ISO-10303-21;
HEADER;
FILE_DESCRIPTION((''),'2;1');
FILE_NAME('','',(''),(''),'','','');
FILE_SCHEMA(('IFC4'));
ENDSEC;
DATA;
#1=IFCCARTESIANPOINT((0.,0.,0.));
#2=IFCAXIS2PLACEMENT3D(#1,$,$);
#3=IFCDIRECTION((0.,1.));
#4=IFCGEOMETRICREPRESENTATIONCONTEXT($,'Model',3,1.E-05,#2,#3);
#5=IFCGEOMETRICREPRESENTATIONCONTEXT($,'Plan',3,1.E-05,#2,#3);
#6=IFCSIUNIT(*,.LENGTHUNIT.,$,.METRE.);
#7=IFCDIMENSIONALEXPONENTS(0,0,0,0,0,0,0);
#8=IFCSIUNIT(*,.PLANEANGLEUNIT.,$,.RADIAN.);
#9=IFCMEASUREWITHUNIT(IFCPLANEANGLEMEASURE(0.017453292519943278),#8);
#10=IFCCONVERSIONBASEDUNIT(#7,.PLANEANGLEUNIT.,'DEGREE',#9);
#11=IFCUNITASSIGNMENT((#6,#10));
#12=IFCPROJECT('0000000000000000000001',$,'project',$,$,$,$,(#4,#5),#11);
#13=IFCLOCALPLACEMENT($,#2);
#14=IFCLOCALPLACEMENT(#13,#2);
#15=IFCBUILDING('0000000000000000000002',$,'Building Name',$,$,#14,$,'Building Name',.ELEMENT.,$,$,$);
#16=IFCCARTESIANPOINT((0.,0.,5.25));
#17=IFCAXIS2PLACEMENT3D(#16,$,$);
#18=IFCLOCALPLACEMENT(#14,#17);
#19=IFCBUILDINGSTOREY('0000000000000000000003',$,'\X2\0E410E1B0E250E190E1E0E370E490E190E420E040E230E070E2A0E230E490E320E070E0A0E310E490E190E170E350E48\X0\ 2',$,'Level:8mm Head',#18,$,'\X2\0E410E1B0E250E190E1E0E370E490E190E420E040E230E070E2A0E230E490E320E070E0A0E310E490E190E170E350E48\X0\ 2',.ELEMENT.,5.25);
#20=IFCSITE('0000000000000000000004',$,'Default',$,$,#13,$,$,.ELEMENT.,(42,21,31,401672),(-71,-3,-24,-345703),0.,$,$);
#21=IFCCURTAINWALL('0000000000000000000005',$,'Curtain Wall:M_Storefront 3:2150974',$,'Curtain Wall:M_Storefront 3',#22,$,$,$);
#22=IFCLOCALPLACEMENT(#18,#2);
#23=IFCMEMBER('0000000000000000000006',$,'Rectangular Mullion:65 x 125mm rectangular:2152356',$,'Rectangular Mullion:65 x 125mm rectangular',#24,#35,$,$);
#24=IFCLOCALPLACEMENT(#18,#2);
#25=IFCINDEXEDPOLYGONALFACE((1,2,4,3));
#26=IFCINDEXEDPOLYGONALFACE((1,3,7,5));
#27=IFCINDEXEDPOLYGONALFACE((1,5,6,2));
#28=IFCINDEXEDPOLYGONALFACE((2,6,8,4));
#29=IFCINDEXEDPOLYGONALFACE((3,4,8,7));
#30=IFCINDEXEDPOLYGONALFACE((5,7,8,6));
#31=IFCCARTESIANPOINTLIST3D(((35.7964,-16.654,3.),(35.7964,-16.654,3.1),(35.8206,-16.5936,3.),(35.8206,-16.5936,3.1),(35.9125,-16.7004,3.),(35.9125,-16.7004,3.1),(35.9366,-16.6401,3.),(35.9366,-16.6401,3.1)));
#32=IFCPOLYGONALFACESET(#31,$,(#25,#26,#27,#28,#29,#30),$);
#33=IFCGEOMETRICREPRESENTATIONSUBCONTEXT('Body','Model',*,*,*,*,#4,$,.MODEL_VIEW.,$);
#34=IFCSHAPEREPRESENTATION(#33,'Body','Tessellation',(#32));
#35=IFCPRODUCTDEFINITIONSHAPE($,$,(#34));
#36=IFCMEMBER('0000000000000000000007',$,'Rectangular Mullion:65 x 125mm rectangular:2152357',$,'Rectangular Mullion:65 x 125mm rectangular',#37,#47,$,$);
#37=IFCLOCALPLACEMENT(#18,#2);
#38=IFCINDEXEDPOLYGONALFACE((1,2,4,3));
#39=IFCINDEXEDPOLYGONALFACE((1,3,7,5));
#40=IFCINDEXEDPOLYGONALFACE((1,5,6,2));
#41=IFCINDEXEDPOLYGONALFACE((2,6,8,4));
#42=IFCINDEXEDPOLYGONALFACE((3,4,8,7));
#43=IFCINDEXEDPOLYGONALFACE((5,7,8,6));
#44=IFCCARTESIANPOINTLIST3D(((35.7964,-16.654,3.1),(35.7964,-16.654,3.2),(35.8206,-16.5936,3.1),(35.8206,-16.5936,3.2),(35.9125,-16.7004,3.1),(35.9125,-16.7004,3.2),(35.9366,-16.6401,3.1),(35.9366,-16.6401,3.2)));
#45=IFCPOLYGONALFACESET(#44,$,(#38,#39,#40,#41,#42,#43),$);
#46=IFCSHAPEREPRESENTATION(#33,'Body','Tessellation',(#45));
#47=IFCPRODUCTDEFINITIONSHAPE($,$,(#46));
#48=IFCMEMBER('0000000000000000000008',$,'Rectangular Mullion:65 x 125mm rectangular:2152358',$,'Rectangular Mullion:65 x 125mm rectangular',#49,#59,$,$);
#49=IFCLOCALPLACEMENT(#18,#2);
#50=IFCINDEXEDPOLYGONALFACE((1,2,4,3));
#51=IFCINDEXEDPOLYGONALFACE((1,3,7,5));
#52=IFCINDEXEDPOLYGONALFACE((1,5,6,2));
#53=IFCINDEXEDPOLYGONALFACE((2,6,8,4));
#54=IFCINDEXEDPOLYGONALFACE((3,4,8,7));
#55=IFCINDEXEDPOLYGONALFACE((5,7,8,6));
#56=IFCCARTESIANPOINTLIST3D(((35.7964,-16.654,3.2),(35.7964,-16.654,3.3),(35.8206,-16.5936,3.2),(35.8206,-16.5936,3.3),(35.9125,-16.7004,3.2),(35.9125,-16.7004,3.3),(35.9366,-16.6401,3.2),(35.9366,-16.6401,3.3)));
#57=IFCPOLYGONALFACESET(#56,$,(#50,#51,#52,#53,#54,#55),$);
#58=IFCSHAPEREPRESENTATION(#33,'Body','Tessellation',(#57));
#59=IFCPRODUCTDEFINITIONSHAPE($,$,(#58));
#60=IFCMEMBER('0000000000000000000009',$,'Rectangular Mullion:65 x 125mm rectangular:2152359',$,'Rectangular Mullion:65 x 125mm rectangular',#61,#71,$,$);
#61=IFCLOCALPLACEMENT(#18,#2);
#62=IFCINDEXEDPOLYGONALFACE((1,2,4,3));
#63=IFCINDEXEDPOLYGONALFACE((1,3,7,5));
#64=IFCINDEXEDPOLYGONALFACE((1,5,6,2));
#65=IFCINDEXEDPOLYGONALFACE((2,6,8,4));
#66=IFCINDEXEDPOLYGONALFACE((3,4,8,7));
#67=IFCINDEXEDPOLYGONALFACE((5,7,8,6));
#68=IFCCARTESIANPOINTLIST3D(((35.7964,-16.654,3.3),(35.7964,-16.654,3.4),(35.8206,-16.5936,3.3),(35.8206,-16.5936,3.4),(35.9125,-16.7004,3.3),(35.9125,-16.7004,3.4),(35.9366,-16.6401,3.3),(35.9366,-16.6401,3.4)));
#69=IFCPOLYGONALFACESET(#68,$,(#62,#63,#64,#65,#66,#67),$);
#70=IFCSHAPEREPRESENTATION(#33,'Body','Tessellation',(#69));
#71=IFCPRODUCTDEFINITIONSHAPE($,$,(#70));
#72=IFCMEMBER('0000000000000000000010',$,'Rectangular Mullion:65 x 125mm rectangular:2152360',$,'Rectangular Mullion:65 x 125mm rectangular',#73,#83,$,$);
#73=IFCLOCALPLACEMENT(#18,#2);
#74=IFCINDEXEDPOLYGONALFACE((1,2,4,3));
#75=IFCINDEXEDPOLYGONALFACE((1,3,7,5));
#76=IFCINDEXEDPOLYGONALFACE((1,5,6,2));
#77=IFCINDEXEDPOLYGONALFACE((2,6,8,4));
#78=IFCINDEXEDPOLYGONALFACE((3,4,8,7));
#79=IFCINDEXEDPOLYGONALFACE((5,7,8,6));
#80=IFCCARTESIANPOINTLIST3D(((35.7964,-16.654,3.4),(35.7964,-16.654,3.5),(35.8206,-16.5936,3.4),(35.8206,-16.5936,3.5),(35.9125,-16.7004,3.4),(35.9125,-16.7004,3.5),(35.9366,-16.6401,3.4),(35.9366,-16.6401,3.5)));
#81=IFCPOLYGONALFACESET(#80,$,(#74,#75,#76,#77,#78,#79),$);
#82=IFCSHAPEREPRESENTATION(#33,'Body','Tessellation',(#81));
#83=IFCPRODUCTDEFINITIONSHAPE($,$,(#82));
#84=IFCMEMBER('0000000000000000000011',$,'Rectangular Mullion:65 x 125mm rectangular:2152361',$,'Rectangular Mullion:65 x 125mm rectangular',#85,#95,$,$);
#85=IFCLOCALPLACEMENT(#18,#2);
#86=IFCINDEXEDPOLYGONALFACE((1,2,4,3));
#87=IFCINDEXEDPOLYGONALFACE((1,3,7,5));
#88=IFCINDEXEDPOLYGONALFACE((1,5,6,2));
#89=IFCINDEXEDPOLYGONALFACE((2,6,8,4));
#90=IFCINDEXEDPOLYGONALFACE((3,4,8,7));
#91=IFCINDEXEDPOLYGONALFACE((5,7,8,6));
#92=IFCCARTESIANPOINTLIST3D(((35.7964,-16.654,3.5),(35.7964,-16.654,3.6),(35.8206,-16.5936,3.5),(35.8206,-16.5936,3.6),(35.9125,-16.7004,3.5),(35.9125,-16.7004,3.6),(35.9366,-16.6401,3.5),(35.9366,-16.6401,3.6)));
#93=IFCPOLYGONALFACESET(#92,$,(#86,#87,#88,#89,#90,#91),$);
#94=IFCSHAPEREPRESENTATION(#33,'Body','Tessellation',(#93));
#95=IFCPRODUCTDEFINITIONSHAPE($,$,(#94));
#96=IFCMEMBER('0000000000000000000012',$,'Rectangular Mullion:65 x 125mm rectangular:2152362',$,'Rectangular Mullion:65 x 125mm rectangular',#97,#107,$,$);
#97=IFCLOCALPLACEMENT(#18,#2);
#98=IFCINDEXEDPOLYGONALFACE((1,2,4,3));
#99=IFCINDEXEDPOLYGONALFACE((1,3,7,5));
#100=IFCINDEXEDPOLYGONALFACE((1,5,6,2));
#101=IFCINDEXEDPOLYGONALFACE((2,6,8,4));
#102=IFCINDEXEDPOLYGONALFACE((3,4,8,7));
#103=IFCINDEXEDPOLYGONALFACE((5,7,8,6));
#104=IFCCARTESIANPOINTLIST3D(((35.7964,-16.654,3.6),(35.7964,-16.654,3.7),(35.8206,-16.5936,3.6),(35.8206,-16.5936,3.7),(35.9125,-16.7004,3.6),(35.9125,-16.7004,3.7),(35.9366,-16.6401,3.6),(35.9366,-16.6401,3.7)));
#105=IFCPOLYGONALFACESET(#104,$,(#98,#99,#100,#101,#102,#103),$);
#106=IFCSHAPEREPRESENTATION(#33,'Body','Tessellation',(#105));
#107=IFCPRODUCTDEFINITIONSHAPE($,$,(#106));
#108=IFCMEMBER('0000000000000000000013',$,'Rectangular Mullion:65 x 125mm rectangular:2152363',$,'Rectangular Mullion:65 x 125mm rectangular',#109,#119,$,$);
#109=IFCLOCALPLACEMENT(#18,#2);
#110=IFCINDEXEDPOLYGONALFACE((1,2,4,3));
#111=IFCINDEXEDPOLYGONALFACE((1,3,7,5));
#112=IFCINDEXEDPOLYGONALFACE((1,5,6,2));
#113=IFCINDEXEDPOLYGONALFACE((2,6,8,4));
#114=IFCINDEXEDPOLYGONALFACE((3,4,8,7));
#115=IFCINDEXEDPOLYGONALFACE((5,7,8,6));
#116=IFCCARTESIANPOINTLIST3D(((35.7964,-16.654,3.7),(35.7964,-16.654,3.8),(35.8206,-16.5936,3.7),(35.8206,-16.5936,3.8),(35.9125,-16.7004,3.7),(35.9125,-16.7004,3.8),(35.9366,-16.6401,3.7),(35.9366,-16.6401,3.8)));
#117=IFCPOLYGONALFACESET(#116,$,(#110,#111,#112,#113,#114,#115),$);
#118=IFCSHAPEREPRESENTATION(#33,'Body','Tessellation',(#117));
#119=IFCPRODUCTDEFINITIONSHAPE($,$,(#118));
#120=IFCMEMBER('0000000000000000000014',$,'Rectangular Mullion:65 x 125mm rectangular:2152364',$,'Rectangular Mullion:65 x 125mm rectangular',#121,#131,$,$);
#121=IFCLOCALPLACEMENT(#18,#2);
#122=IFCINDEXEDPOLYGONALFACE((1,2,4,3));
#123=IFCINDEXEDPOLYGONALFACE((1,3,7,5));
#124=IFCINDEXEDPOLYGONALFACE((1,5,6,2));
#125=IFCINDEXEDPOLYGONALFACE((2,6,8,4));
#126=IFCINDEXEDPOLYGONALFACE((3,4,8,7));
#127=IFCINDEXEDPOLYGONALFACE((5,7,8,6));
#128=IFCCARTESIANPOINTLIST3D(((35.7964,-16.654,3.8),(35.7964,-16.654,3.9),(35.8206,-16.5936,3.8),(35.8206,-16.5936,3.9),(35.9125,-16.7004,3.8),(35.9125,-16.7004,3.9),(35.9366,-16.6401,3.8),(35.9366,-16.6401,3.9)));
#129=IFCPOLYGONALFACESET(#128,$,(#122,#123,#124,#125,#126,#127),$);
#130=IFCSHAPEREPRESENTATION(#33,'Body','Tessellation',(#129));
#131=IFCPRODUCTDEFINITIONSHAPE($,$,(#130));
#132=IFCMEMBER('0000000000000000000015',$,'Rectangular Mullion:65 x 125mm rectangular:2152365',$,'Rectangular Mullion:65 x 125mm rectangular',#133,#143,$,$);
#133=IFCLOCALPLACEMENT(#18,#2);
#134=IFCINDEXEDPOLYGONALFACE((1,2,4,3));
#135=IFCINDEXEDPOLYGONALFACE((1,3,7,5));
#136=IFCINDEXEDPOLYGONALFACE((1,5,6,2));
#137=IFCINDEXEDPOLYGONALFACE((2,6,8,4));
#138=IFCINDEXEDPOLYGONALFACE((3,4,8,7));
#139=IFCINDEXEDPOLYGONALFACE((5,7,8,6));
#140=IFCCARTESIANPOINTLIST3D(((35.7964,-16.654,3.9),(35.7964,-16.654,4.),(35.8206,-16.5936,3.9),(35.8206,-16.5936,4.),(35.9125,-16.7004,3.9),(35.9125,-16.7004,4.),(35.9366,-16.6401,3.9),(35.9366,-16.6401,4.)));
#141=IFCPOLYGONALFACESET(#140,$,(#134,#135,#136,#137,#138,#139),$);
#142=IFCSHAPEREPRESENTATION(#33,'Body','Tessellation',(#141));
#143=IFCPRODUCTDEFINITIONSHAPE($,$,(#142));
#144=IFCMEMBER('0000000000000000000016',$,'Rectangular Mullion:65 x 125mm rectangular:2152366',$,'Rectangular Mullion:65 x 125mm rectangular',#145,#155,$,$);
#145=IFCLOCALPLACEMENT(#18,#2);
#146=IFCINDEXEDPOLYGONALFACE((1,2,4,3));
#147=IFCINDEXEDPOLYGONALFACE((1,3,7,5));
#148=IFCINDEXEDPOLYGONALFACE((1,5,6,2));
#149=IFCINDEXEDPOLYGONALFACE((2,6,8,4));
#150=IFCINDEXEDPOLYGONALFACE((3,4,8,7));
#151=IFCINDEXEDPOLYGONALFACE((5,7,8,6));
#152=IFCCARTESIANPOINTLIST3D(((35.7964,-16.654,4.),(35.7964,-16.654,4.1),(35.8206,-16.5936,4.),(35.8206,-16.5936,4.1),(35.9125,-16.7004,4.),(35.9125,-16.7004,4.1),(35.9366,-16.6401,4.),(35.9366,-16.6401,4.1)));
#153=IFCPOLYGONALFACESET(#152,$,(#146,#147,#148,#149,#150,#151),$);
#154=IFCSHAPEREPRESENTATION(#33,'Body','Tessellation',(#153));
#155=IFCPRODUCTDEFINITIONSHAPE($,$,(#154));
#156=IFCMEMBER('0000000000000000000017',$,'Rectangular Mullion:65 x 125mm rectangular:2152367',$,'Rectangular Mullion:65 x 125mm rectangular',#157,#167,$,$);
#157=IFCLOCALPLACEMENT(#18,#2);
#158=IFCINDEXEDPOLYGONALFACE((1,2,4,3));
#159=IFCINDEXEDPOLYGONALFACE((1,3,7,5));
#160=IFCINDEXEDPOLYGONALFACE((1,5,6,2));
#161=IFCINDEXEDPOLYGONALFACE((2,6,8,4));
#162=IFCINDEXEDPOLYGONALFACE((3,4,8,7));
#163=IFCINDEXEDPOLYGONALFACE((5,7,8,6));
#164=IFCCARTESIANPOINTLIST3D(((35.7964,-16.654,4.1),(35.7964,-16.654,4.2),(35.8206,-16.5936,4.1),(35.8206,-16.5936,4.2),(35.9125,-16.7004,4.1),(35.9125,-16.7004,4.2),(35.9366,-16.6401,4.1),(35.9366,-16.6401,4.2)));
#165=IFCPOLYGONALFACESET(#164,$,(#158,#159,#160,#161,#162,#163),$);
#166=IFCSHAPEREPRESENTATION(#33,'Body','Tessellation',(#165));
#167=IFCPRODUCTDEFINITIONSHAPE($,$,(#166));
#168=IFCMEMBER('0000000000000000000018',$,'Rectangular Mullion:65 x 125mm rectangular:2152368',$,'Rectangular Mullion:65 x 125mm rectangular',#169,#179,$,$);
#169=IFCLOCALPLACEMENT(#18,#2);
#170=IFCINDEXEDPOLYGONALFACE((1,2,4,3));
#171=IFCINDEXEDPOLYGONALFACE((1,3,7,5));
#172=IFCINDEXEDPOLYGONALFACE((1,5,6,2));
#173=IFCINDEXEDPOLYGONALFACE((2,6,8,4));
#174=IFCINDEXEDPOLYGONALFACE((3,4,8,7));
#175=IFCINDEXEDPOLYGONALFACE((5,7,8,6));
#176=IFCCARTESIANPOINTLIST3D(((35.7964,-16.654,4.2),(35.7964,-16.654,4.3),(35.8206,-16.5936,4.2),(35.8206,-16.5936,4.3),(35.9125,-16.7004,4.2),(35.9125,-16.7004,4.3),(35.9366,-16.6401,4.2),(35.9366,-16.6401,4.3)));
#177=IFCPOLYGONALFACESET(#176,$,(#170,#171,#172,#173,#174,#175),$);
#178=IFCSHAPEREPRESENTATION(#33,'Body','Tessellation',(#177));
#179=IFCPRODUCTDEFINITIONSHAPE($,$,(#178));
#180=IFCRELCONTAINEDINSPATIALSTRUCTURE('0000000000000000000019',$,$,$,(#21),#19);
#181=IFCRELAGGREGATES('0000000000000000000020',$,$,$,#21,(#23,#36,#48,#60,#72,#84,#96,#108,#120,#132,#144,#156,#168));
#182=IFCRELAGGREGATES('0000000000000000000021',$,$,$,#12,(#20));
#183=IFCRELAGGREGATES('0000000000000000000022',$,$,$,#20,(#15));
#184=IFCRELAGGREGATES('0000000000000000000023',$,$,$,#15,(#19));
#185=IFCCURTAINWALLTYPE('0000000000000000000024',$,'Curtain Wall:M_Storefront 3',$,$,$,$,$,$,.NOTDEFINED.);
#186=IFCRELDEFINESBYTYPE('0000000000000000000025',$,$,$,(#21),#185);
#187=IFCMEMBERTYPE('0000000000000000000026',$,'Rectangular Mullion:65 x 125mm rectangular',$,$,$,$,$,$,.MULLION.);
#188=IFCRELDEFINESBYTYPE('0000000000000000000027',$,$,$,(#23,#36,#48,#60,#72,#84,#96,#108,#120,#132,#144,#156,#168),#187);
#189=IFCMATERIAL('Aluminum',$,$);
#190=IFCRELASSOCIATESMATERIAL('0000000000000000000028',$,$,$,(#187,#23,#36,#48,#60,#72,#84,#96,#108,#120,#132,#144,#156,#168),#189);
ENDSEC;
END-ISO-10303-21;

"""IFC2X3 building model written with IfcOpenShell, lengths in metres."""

from ifc_helpers import new_model, entity, si_unit, converted_unit, direction, frame, origin, origin_2d_with_axis, place, context, subcontext, project, spatial, rectangle, extrude, source, transform, mapped, material, type_object, type_shapes, element, aggregate, save


model = new_model("IFC2X3")

# Units and contexts
model_context = context("Model", 3, precision=1e-05, world=origin(), true_north=direction((0.0, 1.0)))
plan_context = context("Plan", 3, precision=1e-05, world=origin(), true_north=direction((0.0, 1.0)))
body_context = subcontext(model_context, "Body", "Model", "MODEL_VIEW")
ifc_project = project(units=[si_unit("LENGTHUNIT", "METRE"), converted_unit("PLANEANGLEUNIT", "DEGREE", entity("IfcPlaneAngleMeasure", 0.017453292519943278), si_unit("PLANEANGLEUNIT", "RADIAN"), dimensions=[0, 0, 0, 0, 0, 0, 0])], contexts=[model_context, plan_context])

# Site, building, storey
site_placement = place(None, origin())
site = spatial("IfcSite", under=ifc_project, at=site_placement, Name="Default", CompositionType="ELEMENT", RefLatitude=(42, 21, 31, 401672), RefLongitude=(-71, -3, -24, -345703), RefElevation=0.0)
building_placement = place(site_placement, origin())
building = spatial("IfcBuilding", under=site, at=building_placement, Name="Building Name", LongName="Building Name", CompositionType="ELEMENT")
storey_placement = place(building_placement, frame((0.0, 0.0, 5.25)))
storey = spatial("IfcBuildingStorey", under=building, at=storey_placement, Name="แปลนพื้นโครงสร้างชั้นที่ 2", ObjectType="Level:8mm Head", LongName="แปลนพื้นโครงสร้างชั้นที่ 2", CompositionType="ELEMENT", Elevation=5.25)

# Curtain wall
curtain_wall_type = type_object("IfcCurtainWallType", Name="Curtain Wall:M_Storefront 3", PredefinedType="NOTDEFINED")
curtain_wall_1_placement = place(storey_placement, frame((0.0, 0.0, -5.25)))
curtain_wall_1 = element("IfcCurtainWall", 1, at=curtain_wall_1_placement, inside=storey, type_object=curtain_wall_type, Name="Curtain Wall:M_Storefront 3:2150974", ObjectType="Curtain Wall:M_Storefront 3")
ifc_material = material(Name="Aluminum")

# Members
member_type_1 = type_object("IfcMemberType", Name="Rectangular Mullion:65 x 125mm rectangular", PredefinedType="MULLION", material=ifc_material)
shared_shape_1 = source(origin(), body_context, "Body", "SweptSolid", [
    extrude(rectangle(XDim=0.065, YDim=0.125, at=origin_2d_with_axis()), frame((-0.0325, 0.0, -0.1), z_axis=(0.0, 0.0, 1.0), x_axis=(-1.0, 0.0, 0.0)), (0.0, 0.0, 1.0), 0.1),
])
type_shapes(member_type_1, [shared_shape_1])
member_1_placement = place(curtain_wall_1_placement, frame((35.8545, -16.6772, 8.35), z_axis=(0.0, 0.0, 1.0), x_axis=(-0.371573, -0.928404, 0.0)))
member_1 = element("IfcMember", 2, at=member_1_placement, type_object=member_type_1, material=ifc_material, Name="Rectangular Mullion:65 x 125mm rectangular:2152356", ObjectType="Rectangular Mullion:65 x 125mm rectangular", context=body_context, shape_type="MappedRepresentation", body=[
    mapped(shared_shape_1, transform((0.0, 0.0, 0.0), scale=1.0)),
])
member_2_placement = place(curtain_wall_1_placement, frame((35.8545, -16.6772, 8.45), z_axis=(0.0, 0.0, 1.0), x_axis=(-0.371573, -0.928404, 0.0)))
member_2 = element("IfcMember", 3, at=member_2_placement, type_object=member_type_1, material=ifc_material, Name="Rectangular Mullion:65 x 125mm rectangular:2152357", ObjectType="Rectangular Mullion:65 x 125mm rectangular", context=body_context, shape_type="MappedRepresentation", body=[
    mapped(shared_shape_1, transform((0.0, 0.0, 0.0), scale=1.0)),
])
member_3_placement = place(curtain_wall_1_placement, frame((35.8545, -16.6772, 8.55), z_axis=(0.0, 0.0, 1.0), x_axis=(-0.371573, -0.928404, 0.0)))
member_3 = element("IfcMember", 4, at=member_3_placement, type_object=member_type_1, material=ifc_material, Name="Rectangular Mullion:65 x 125mm rectangular:2152358", ObjectType="Rectangular Mullion:65 x 125mm rectangular", context=body_context, shape_type="MappedRepresentation", body=[
    mapped(shared_shape_1, transform((0.0, 0.0, 0.0), scale=1.0)),
])
member_4_placement = place(curtain_wall_1_placement, frame((35.8545, -16.6772, 8.65), z_axis=(0.0, 0.0, 1.0), x_axis=(-0.371573, -0.928404, 0.0)))
member_4 = element("IfcMember", 5, at=member_4_placement, type_object=member_type_1, material=ifc_material, Name="Rectangular Mullion:65 x 125mm rectangular:2152359", ObjectType="Rectangular Mullion:65 x 125mm rectangular", context=body_context, shape_type="MappedRepresentation", body=[
    mapped(shared_shape_1, transform((0.0, 0.0, 0.0), scale=1.0)),
])
member_5_placement = place(curtain_wall_1_placement, frame((35.8545, -16.6772, 8.75), z_axis=(0.0, 0.0, 1.0), x_axis=(-0.371573, -0.928404, 0.0)))
member_5 = element("IfcMember", 6, at=member_5_placement, type_object=member_type_1, material=ifc_material, Name="Rectangular Mullion:65 x 125mm rectangular:2152360", ObjectType="Rectangular Mullion:65 x 125mm rectangular", context=body_context, shape_type="MappedRepresentation", body=[
    mapped(shared_shape_1, transform((0.0, 0.0, 0.0), scale=1.0)),
])
member_6_placement = place(curtain_wall_1_placement, frame((35.8545, -16.6772, 8.85), z_axis=(0.0, 0.0, 1.0), x_axis=(-0.371573, -0.928404, 0.0)))
member_6 = element("IfcMember", 7, at=member_6_placement, type_object=member_type_1, material=ifc_material, Name="Rectangular Mullion:65 x 125mm rectangular:2152361", ObjectType="Rectangular Mullion:65 x 125mm rectangular", context=body_context, shape_type="MappedRepresentation", body=[
    mapped(shared_shape_1, transform((0.0, 0.0, 0.0), scale=1.0)),
])
member_7_placement = place(curtain_wall_1_placement, frame((35.8545, -16.6772, 8.95), z_axis=(0.0, 0.0, 1.0), x_axis=(-0.371573, -0.928404, 0.0)))
member_7 = element("IfcMember", 8, at=member_7_placement, type_object=member_type_1, material=ifc_material, Name="Rectangular Mullion:65 x 125mm rectangular:2152362", ObjectType="Rectangular Mullion:65 x 125mm rectangular", context=body_context, shape_type="MappedRepresentation", body=[
    mapped(shared_shape_1, transform((0.0, 0.0, 0.0), scale=1.0)),
])
member_8_placement = place(curtain_wall_1_placement, frame((35.8545, -16.6772, 9.05), z_axis=(0.0, 0.0, 1.0), x_axis=(-0.371573, -0.928404, 0.0)))
member_8 = element("IfcMember", 9, at=member_8_placement, type_object=member_type_1, material=ifc_material, Name="Rectangular Mullion:65 x 125mm rectangular:2152363", ObjectType="Rectangular Mullion:65 x 125mm rectangular", context=body_context, shape_type="MappedRepresentation", body=[
    mapped(shared_shape_1, transform((0.0, 0.0, 0.0), scale=1.0)),
])
member_9_placement = place(curtain_wall_1_placement, frame((35.8545, -16.6772, 9.15), z_axis=(0.0, 0.0, 1.0), x_axis=(-0.371573, -0.928404, 0.0)))
member_9 = element("IfcMember", 10, at=member_9_placement, type_object=member_type_1, material=ifc_material, Name="Rectangular Mullion:65 x 125mm rectangular:2152364", ObjectType="Rectangular Mullion:65 x 125mm rectangular", context=body_context, shape_type="MappedRepresentation", body=[
    mapped(shared_shape_1, transform((0.0, 0.0, 0.0), scale=1.0)),
])
member_10_placement = place(curtain_wall_1_placement, frame((35.8545, -16.6772, 9.25), z_axis=(0.0, 0.0, 1.0), x_axis=(-0.371573, -0.928404, 0.0)))
member_10 = element("IfcMember", 11, at=member_10_placement, type_object=member_type_1, material=ifc_material, Name="Rectangular Mullion:65 x 125mm rectangular:2152365", ObjectType="Rectangular Mullion:65 x 125mm rectangular", context=body_context, shape_type="MappedRepresentation", body=[
    mapped(shared_shape_1, transform((0.0, 0.0, 0.0), scale=1.0)),
])
member_11_placement = place(curtain_wall_1_placement, frame((35.8545, -16.6772, 9.35), z_axis=(0.0, 0.0, 1.0), x_axis=(-0.371573, -0.928404, 0.0)))
member_11 = element("IfcMember", 12, at=member_11_placement, type_object=member_type_1, material=ifc_material, Name="Rectangular Mullion:65 x 125mm rectangular:2152366", ObjectType="Rectangular Mullion:65 x 125mm rectangular", context=body_context, shape_type="MappedRepresentation", body=[
    mapped(shared_shape_1, transform((0.0, 0.0, 0.0), scale=1.0)),
])
member_12_placement = place(curtain_wall_1_placement, frame((35.8545, -16.6772, 9.45), z_axis=(0.0, 0.0, 1.0), x_axis=(-0.371573, -0.928404, 0.0)))
member_12 = element("IfcMember", 13, at=member_12_placement, type_object=member_type_1, material=ifc_material, Name="Rectangular Mullion:65 x 125mm rectangular:2152367", ObjectType="Rectangular Mullion:65 x 125mm rectangular", context=body_context, shape_type="MappedRepresentation", body=[
    mapped(shared_shape_1, transform((0.0, 0.0, 0.0), scale=1.0)),
])
member_13_placement = place(curtain_wall_1_placement, frame((35.8545, -16.6772, 9.55), z_axis=(0.0, 0.0, 1.0), x_axis=(-0.371573, -0.928404, 0.0)))
member_13 = element("IfcMember", 14, at=member_13_placement, type_object=member_type_1, material=ifc_material, Name="Rectangular Mullion:65 x 125mm rectangular:2152368", ObjectType="Rectangular Mullion:65 x 125mm rectangular", context=body_context, shape_type="MappedRepresentation", body=[
    mapped(shared_shape_1, transform((0.0, 0.0, 0.0), scale=1.0)),
])
aggregate(curtain_wall_1, [member_1, member_2, member_3, member_4, member_5, member_6, member_7, member_8, member_9, member_10, member_11, member_12, member_13])

save(model, "model.ifc")
